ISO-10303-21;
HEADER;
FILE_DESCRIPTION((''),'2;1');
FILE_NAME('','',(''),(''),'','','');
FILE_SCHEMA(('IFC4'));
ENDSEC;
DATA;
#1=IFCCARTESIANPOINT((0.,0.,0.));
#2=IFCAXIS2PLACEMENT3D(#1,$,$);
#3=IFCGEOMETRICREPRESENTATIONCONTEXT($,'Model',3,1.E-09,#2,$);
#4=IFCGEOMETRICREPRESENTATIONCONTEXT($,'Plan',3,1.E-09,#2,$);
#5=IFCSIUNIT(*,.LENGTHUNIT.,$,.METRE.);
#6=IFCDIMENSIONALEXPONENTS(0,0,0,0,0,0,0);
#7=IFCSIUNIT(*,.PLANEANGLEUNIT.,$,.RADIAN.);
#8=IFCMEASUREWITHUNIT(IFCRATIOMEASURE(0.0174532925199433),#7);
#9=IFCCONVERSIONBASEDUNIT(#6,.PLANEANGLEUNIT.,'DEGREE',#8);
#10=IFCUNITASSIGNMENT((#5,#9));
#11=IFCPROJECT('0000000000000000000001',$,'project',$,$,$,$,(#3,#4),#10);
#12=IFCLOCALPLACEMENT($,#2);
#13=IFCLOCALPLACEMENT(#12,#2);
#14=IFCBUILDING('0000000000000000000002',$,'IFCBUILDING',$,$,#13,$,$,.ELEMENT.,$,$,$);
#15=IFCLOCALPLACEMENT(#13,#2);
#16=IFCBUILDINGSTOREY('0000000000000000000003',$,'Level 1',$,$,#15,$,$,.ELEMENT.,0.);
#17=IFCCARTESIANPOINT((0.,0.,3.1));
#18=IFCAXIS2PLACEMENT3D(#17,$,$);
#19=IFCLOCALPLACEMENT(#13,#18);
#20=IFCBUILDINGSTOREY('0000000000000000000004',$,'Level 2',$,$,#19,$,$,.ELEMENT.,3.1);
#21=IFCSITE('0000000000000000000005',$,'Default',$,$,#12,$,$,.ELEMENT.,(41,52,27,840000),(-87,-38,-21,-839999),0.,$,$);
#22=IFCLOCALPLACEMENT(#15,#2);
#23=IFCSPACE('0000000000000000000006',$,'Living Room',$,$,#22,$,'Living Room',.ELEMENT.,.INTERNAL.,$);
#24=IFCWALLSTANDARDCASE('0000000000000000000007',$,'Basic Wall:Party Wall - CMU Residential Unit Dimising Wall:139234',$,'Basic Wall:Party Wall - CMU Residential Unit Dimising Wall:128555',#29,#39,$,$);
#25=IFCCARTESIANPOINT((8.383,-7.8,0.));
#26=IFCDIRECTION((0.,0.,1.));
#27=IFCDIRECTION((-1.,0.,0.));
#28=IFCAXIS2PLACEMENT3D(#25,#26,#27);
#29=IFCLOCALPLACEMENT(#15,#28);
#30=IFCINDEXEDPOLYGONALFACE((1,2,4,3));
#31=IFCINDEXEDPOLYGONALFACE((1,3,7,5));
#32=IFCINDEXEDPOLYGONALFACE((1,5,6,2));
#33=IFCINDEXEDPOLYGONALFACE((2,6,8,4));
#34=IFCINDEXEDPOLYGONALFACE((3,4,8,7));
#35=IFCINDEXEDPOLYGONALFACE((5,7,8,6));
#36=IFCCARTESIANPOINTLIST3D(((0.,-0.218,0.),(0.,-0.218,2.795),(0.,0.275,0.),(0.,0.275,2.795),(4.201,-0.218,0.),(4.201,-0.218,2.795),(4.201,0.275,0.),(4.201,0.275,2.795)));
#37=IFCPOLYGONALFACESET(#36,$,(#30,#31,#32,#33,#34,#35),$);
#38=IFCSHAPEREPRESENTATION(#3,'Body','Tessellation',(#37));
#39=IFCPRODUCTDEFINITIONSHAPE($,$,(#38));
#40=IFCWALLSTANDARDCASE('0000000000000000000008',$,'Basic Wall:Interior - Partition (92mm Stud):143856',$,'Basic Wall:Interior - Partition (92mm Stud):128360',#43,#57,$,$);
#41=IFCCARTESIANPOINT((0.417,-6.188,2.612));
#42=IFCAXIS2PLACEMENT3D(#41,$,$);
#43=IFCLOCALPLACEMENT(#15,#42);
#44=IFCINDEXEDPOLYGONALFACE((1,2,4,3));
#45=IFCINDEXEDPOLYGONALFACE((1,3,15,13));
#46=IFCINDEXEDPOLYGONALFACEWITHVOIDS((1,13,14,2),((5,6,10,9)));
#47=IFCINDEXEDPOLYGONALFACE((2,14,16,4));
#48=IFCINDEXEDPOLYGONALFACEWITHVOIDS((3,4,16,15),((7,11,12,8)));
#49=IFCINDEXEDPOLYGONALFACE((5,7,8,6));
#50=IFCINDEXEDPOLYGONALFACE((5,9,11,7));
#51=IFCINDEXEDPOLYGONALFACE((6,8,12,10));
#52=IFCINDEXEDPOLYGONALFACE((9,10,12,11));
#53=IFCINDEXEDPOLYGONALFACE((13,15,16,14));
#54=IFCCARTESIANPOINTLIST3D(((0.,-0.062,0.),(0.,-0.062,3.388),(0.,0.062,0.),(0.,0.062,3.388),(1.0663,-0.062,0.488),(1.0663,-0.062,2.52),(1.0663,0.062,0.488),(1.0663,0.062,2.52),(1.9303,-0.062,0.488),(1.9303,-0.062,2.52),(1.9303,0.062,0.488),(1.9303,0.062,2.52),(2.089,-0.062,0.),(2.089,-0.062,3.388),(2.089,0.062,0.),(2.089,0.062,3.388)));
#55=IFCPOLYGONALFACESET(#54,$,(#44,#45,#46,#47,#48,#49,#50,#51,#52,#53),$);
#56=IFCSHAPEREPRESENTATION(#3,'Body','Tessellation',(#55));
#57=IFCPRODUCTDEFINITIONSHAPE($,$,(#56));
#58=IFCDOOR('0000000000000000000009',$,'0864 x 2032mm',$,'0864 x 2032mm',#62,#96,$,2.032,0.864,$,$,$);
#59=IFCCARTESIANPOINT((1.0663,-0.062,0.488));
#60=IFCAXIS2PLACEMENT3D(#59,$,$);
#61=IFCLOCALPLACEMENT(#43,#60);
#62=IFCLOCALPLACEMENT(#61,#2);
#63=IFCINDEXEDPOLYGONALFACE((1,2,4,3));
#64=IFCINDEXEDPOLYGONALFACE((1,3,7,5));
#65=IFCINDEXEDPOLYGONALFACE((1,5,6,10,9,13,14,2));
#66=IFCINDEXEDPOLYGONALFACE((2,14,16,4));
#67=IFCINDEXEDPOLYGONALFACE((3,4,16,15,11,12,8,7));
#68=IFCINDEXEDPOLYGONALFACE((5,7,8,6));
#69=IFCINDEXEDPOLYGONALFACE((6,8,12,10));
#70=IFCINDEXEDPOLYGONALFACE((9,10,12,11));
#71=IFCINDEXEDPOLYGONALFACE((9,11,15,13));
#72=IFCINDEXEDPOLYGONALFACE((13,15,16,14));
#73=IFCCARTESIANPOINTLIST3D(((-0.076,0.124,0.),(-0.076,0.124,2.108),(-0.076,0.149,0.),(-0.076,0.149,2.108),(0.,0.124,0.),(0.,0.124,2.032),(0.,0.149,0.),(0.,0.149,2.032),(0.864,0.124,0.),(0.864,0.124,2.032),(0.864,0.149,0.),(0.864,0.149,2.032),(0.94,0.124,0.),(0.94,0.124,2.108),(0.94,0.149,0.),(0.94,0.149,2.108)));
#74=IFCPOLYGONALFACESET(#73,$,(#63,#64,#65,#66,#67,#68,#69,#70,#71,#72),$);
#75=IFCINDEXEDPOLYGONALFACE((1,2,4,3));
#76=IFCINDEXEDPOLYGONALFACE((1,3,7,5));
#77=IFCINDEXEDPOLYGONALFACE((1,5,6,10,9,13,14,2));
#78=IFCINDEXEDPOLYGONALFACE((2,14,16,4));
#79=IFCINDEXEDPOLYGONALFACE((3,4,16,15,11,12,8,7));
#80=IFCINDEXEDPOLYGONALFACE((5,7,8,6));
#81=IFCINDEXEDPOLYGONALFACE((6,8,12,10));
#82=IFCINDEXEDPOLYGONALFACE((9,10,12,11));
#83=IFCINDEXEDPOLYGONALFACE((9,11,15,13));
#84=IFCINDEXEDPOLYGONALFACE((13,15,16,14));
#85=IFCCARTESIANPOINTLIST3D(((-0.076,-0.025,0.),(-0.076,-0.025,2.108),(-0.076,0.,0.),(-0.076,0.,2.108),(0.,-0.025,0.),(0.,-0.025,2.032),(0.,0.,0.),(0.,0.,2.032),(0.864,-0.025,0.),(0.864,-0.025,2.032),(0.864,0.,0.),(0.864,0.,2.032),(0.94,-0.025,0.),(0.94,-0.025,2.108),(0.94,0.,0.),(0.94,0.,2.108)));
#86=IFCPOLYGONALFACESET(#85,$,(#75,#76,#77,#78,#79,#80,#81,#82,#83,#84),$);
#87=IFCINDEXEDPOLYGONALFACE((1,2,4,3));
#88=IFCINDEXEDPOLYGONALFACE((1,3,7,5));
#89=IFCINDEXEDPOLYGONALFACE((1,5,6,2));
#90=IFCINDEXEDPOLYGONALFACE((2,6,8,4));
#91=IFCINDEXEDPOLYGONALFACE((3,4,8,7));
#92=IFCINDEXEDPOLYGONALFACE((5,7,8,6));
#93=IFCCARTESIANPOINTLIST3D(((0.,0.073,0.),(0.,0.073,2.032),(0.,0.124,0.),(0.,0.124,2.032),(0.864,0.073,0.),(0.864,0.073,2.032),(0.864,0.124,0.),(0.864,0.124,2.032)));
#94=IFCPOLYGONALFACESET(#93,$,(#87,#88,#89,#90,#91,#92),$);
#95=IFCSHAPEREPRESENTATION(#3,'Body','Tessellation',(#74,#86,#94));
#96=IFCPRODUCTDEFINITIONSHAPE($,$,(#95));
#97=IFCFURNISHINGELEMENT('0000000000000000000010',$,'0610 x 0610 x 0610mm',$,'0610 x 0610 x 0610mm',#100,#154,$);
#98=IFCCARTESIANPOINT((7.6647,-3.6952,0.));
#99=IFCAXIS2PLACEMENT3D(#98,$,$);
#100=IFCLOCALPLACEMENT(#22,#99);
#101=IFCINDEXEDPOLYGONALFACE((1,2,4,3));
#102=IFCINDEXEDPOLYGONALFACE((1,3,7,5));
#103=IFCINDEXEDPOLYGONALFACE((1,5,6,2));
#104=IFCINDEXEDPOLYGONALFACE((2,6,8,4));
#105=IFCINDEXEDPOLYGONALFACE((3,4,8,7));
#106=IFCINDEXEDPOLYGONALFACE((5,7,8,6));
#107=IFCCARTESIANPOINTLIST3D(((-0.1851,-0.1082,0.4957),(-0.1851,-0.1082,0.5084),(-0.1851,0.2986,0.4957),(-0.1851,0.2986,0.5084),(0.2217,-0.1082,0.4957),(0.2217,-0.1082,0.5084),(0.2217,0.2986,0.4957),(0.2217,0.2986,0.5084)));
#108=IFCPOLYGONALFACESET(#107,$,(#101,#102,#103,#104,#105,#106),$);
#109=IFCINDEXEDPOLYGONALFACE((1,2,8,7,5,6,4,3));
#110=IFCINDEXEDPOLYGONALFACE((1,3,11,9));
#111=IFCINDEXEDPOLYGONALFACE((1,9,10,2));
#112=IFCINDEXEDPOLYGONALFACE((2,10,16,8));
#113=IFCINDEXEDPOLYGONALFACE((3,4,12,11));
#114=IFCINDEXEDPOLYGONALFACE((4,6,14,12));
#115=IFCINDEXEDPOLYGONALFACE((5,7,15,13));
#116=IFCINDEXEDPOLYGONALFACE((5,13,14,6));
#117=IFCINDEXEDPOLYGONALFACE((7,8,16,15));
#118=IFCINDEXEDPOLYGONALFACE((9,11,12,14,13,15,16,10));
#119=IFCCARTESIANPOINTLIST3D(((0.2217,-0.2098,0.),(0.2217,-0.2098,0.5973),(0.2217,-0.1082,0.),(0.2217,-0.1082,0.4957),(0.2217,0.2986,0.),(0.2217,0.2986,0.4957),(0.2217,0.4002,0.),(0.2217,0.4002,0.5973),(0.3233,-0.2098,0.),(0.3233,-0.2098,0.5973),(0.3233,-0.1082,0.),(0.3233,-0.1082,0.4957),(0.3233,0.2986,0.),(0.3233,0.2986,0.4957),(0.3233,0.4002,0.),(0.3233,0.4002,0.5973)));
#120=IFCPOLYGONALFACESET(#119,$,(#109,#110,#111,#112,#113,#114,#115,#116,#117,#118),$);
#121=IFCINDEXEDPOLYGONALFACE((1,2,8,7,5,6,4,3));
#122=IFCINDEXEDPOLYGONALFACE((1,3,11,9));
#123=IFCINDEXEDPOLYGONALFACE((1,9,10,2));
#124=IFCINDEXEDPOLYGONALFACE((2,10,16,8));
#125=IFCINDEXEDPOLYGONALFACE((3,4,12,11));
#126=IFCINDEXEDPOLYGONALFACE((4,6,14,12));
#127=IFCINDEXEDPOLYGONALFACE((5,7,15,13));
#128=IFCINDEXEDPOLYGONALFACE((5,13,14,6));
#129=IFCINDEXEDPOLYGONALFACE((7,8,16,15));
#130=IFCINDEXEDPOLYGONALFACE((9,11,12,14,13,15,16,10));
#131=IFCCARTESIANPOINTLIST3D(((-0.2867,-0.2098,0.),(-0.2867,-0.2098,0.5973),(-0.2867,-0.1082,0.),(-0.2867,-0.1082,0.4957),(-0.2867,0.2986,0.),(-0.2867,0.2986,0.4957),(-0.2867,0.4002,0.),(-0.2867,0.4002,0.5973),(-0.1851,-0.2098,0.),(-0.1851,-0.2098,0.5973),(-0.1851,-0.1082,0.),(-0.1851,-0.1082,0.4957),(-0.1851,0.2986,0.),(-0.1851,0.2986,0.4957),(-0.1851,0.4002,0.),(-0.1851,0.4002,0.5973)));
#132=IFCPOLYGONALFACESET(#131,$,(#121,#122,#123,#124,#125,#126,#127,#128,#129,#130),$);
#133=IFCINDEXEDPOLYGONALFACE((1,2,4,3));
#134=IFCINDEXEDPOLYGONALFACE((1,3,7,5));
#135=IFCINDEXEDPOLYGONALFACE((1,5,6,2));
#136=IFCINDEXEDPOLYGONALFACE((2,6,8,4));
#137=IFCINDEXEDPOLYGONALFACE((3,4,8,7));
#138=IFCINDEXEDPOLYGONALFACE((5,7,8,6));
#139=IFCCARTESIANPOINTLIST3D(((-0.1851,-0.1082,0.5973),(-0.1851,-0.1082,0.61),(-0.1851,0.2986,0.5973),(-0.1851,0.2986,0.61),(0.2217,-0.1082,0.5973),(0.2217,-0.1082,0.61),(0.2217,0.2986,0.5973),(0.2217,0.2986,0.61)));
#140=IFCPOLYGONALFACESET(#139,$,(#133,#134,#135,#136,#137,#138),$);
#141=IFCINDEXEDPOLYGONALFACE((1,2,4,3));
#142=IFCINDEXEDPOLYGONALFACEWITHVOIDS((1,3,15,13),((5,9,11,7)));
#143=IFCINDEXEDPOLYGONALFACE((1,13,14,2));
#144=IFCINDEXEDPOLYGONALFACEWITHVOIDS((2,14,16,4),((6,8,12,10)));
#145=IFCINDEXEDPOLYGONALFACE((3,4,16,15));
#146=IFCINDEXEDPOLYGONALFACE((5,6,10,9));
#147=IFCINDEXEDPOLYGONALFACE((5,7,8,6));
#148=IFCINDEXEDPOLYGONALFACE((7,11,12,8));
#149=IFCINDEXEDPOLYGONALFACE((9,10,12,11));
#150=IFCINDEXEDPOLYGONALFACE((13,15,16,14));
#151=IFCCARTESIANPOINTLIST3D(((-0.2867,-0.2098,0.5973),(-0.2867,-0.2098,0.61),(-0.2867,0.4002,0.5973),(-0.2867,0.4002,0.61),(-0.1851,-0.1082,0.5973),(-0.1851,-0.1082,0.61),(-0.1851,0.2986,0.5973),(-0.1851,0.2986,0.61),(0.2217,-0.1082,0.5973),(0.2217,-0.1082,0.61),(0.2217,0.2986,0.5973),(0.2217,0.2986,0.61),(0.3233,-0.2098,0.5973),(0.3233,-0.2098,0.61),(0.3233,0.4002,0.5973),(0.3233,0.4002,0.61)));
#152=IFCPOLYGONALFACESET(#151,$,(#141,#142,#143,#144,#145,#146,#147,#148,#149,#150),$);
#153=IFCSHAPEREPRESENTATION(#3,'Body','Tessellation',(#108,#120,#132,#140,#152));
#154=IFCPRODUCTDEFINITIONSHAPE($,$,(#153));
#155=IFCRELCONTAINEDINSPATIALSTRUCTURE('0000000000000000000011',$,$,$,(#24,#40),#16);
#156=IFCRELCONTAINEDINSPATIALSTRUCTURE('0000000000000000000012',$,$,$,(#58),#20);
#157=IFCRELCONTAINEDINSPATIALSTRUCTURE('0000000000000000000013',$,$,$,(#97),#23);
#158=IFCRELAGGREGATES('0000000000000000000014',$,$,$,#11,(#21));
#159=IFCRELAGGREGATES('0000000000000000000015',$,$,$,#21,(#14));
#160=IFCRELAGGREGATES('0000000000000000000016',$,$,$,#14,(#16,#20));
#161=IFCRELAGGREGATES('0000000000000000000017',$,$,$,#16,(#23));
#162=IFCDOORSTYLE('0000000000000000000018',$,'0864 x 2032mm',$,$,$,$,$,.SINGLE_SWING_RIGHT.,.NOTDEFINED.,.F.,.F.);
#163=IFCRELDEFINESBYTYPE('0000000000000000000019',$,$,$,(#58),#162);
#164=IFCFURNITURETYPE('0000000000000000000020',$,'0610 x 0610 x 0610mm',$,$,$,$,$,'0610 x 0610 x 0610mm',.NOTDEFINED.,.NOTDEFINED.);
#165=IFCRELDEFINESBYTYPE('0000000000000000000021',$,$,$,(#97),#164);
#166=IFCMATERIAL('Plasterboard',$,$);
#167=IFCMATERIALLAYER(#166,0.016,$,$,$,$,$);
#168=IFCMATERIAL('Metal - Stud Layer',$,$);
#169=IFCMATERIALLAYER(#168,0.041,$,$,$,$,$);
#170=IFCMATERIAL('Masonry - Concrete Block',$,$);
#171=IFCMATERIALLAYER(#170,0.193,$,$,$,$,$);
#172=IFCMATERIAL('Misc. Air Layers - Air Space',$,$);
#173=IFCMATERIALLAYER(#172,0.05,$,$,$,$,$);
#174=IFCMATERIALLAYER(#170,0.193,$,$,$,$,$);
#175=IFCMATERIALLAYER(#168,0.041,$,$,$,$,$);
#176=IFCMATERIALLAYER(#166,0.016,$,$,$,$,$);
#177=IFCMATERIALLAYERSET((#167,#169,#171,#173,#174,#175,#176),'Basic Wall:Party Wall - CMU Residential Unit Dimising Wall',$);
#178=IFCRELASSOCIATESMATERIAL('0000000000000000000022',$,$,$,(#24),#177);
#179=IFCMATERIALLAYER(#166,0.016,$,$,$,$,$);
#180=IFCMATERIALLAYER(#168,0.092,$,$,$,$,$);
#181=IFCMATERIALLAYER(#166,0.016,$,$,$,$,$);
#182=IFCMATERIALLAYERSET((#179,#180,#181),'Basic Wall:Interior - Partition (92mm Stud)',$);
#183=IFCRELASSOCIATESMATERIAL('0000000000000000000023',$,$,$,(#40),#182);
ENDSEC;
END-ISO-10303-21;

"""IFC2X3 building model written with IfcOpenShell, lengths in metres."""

from ifc_helpers import new_model, entity, si_unit, converted_unit, frame, frame_2d, origin, origin_2d_with_axis, place, context, project, spatial, polyline, rectangle, outline, extrude, clip, bounded_halfspace, source, transform, mapped, material, layer, layer_set, layer_usage, type_object, type_shapes, element, fill, save


model = new_model("IFC2X3")

# Units and contexts
model_context = context("Model", 3, precision=1e-09, world=origin())
plan_context = context("Plan", 3, precision=1e-09, world=origin())
ifc_project = project(units=[si_unit("LENGTHUNIT", "METRE"), converted_unit("PLANEANGLEUNIT", "DEGREE", entity("IfcRatioMeasure", 0.0174532925199433), si_unit("PLANEANGLEUNIT", "RADIAN"), dimensions=[0, 0, 0, 0, 0, 0, 0])], contexts=[model_context, plan_context])

# Site, building, storey
site_placement = place(None, origin())
site = spatial("IfcSite", under=ifc_project, at=site_placement, Name="Default", CompositionType="ELEMENT", RefLatitude=(41, 52, 27, 840000), RefLongitude=(-87, -38, -21, -839999), RefElevation=0.0)
building_placement = place(site_placement, origin())
building = spatial("IfcBuilding", under=site, at=building_placement, Name="IFCBUILDING", CompositionType="ELEMENT")
storey_1_placement = place(building_placement, origin())
storey_1 = spatial("IfcBuildingStorey", under=building, at=storey_1_placement, Name="Level 1", CompositionType="ELEMENT", Elevation=0.0)

# Shared definitions
ifc_material_1 = material(Name="Misc. Air Layers - Air Space")
ifc_material_2 = material(Name="Masonry - Concrete Block")
ifc_material_3 = material(Name="Metal - Stud Layer")
ifc_material_4 = material(Name="Plasterboard")

# Shared definitions
ifc_layer_1 = layer(ifc_material_4, 0.016)
ifc_layer_2 = layer(ifc_material_3, 0.092)
ifc_layer_3 = layer(ifc_material_4, 0.016)
ifc_layer_set_1 = layer_set([ifc_layer_1, ifc_layer_2, ifc_layer_3], Name="Basic Wall:Interior - Partition (92mm Stud)")

# Wall
ifc_layer_4 = layer(ifc_material_4, 0.016)
ifc_layer_5 = layer(ifc_material_3, 0.041)
ifc_layer_6 = layer(ifc_material_2, 0.193)
ifc_layer_7 = layer(ifc_material_1, 0.05)
ifc_layer_8 = layer(ifc_material_2, 0.193)
ifc_layer_9 = layer(ifc_material_3, 0.041)
ifc_layer_10 = layer(ifc_material_4, 0.016)
ifc_layer_set_2 = layer_set([ifc_layer_4, ifc_layer_5, ifc_layer_6, ifc_layer_7, ifc_layer_8, ifc_layer_9, ifc_layer_10], Name="Basic Wall:Party Wall - CMU Residential Unit Dimising Wall")
ifc_layer_usage_1 = layer_usage(ifc_layer_set_2, "AXIS2", "NEGATIVE", 0.275)
wall_1_placement = place(storey_1_placement, frame((8.383, -7.8, 0.0), z_axis=(0.0, 0.0, 1.0), x_axis=(-1.0, 0.0, 0.0)))
element("IfcWallStandardCase", 1, at=wall_1_placement, inside=storey_1, material=ifc_layer_usage_1, Name="Basic Wall:Party Wall - CMU Residential Unit Dimising Wall:139234", ObjectType="Basic Wall:Party Wall - CMU Residential Unit Dimising Wall:128555", context=model_context, shape_type="Clipping", body=[
    clip(clip(extrude(rectangle(XDim=4.201, YDim=0.55, at=frame_2d((2.1005, 0.0), x_axis=(-1.0, 0.0))), origin(), (0.0, 0.0, 1.0), 2.795), bounded_halfspace(frame((0.0, -0.218, 2.795), z_axis=(0.0, 1.0, 0.0), x_axis=(-1.0, 0.0, 0.0)), True, frame((0.0, -0.218, 2.795), z_axis=(0.0, 1.0, 0.0), x_axis=(-1.0, 0.0, 0.0)), polyline([(0.0, 0.0), (-3.708, 0.0), (-4.201, 0.0), (-4.201, -2.795), (0.0, -2.795), (0.0, 0.0)]))), bounded_halfspace(frame((4.201, 0.275, 0.0), z_axis=(-1.0, 0.0, 0.0), x_axis=(0.0, -1.0, 0.0)), True, frame((4.201, 0.275, 0.0), z_axis=(-1.0, 0.0, 0.0), x_axis=(0.0, -1.0, 0.0)), polyline([(0.0, 0.0), (0.493, 0.0), (0.493, 2.795), (0.0, 2.795), (0.0, 0.0)]))),
])

# Wall, opening
ifc_layer_usage_2 = layer_usage(ifc_layer_set_1, "AXIS2", "NEGATIVE", 0.062)
wall_2_placement = place(storey_1_placement, frame((0.417, -6.188, 2.612)))
wall_2 = element("IfcWallStandardCase", 2, at=wall_2_placement, inside=storey_1, material=ifc_layer_usage_2, Name="Basic Wall:Interior - Partition (92mm Stud):143856", ObjectType="Basic Wall:Interior - Partition (92mm Stud):128360", context=model_context, shape_type="SweptSolid", body=[
    extrude(rectangle(XDim=2.089, YDim=0.124, at=frame_2d((1.0445, 0.0), x_axis=(-1.0, 0.0))), origin(), (0.0, 0.0, 1.0), 3.388),
])
opening_1_placement = place(wall_2_placement, frame((1.0663, -0.062, 0.488)))
opening_1 = element("IfcOpeningElement", 3, at=opening_1_placement, cuts=wall_2, ObjectType="Opening", context=model_context, shape_type="SweptSolid", body=[
    extrude(rectangle(XDim=0.864, YDim=2.032, at=frame_2d((1.016, 0.432), x_axis=(0.0, 1.0))), frame((0.0, 0.0, 0.0), z_axis=(0.0, 1.0, 0.0), x_axis=(0.0, 0.0, 1.0)), (0.0, 0.0, 1.0), 0.124),
])

# Shared definitions
storey_2_placement = place(building_placement, frame((0.0, 0.0, 3.1)))
storey_2 = spatial("IfcBuildingStorey", under=building, at=storey_2_placement, Name="Level 2", CompositionType="ELEMENT", Elevation=3.1)

# Door
door_style_1 = type_object("IfcDoorStyle", Name="0864 x 2032mm", ConstructionType="NOTDEFINED", OperationType="SINGLE_SWING_RIGHT", ParameterTakesPrecedence=False, Sizeable=False)
shared_shape_1 = source(origin(), model_context, "Body", "SweptSolid", [
    extrude(outline(polyline([(-0.508, -1.073), (0.508, -1.073), (0.508, 1.035), (0.432, 1.035), (0.432, -0.997), (-0.432, -0.997), (-0.432, 1.035), (-0.508, 1.035), (-0.508, -1.073)])), frame((0.432, 0.124, 1.035), z_axis=(0.0, 1.0, 0.0), x_axis=(1.0, 0.0, 0.0)), (0.0, 0.0, 1.0), 0.025),
    extrude(outline(polyline([(-1.073, -0.508), (1.035, -0.508), (1.035, -0.432), (-0.997, -0.432), (-0.997, 0.432), (1.035, 0.432), (1.035, 0.508), (-1.073, 0.508), (-1.073, -0.508)])), frame((0.432, -0.025, 1.035), z_axis=(0.0, 1.0, 0.0), x_axis=(0.0, 0.0, -1.0)), (0.0, 0.0, 1.0), 0.025),
    extrude(rectangle(XDim=0.051, YDim=0.864, at=origin_2d_with_axis()), frame((0.432, 0.0985, 0.0), z_axis=(0.0, 0.0, 1.0), x_axis=(0.0, 1.0, 0.0)), (0.0, 0.0, 1.0), 2.032),
])
type_shapes(door_style_1, [shared_shape_1])
door_1_placement = place(opening_1_placement, origin())
door_1 = element("IfcDoor", 4, at=door_1_placement, inside=storey_2, type_object=door_style_1, Name="0864 x 2032mm", ObjectType="0864 x 2032mm", OverallHeight=2.032, OverallWidth=0.864, context=model_context, shape_type="MappedRepresentation", body=[
    mapped(shared_shape_1, transform((0.0, 0.0, 0.0), scale=1.0)),
])
fill(opening_1, door_1)

# Shared definitions
space_1_placement = place(storey_1_placement, origin())
space_1 = spatial("IfcSpace", under=storey_1, at=space_1_placement, Name="Living Room", LongName="Living Room", CompositionType="ELEMENT", InteriorOrExteriorSpace="INTERNAL")

# Furnishing element
furniture_type_1 = type_object("IfcFurnitureType", Name="0610 x 0610 x 0610mm", ElementType="0610 x 0610 x 0610mm", AssemblyPlace="NOTDEFINED")
shared_shape_2 = source(origin(), model_context, "Body", "SweptSolid", [
    extrude(rectangle(XDim=0.4068, YDim=0.4068, at=origin_2d_with_axis()), frame((0.0183, 0.0952, 0.4957), z_axis=(0.0, 0.0, 1.0), x_axis=(-1.0, 0.0, 0.0)), (0.0, 0.0, 1.0), 0.0127),
    extrude(outline(polyline([(-0.2732, -0.305), (0.324, -0.305), (0.324, 0.305), (-0.2732, 0.305), (-0.2732, 0.2034), (0.2225, 0.2034), (0.2225, -0.2034), (-0.2732, -0.2034), (-0.2732, -0.305)])), frame((0.2217, 0.0952, 0.2732), z_axis=(1.0, 0.0, 0.0), x_axis=(0.0, 0.0, 1.0)), (0.0, 0.0, 1.0), 0.1016),
    extrude(outline(polyline([(-0.305, -0.3241), (0.305, -0.3241), (0.305, 0.2733), (0.2034, 0.2733), (0.2034, -0.2224), (-0.2034, -0.2224), (-0.2034, 0.2733), (-0.305, 0.2733), (-0.305, -0.3241)])), frame((-0.2867, 0.0952, 0.2733), z_axis=(1.0, 0.0, 0.0), x_axis=(0.0, -1.0, 0.0)), (0.0, 0.0, 1.0), 0.1016),
    extrude(rectangle(XDim=0.4068, YDim=0.4068, at=origin_2d_with_axis()), frame((0.0183, 0.0952, 0.5973), z_axis=(0.0, 0.0, 1.0), x_axis=(-1.0, 0.0, 0.0)), (0.0, 0.0, 1.0), 0.0127),
    extrude(outline(polyline([(-0.305, -0.305), (0.305, -0.305), (0.305, 0.305), (-0.305, 0.305), (-0.305, -0.305)]), holes=[polyline([(-0.2034, -0.2034), (-0.2034, 0.2034), (0.2034, 0.2034), (0.2034, -0.2034), (-0.2034, -0.2034)])]), frame((0.0183, 0.0952, 0.5973), z_axis=(0.0, 0.0, 1.0), x_axis=(-1.0, 0.0, 0.0)), (0.0, 0.0, 1.0), 0.0127),
])
type_shapes(furniture_type_1, [shared_shape_2])
for number, where, name in (
    (5, (7.6647, -3.6952, 0.0), "0610 x 0610 x 0610mm"),
):
    element("IfcFurnishingElement", number, at=place(space_1_placement, frame(where)), inside=space_1, type_object=furniture_type_1, Name=name, ObjectType="0610 x 0610 x 0610mm", context=model_context, shape_type="MappedRepresentation", body=[
        mapped(shared_shape_2, transform((0.0, 0.0, 0.0), scale=1.0)),
    ])

save(model, "model.ifc")
